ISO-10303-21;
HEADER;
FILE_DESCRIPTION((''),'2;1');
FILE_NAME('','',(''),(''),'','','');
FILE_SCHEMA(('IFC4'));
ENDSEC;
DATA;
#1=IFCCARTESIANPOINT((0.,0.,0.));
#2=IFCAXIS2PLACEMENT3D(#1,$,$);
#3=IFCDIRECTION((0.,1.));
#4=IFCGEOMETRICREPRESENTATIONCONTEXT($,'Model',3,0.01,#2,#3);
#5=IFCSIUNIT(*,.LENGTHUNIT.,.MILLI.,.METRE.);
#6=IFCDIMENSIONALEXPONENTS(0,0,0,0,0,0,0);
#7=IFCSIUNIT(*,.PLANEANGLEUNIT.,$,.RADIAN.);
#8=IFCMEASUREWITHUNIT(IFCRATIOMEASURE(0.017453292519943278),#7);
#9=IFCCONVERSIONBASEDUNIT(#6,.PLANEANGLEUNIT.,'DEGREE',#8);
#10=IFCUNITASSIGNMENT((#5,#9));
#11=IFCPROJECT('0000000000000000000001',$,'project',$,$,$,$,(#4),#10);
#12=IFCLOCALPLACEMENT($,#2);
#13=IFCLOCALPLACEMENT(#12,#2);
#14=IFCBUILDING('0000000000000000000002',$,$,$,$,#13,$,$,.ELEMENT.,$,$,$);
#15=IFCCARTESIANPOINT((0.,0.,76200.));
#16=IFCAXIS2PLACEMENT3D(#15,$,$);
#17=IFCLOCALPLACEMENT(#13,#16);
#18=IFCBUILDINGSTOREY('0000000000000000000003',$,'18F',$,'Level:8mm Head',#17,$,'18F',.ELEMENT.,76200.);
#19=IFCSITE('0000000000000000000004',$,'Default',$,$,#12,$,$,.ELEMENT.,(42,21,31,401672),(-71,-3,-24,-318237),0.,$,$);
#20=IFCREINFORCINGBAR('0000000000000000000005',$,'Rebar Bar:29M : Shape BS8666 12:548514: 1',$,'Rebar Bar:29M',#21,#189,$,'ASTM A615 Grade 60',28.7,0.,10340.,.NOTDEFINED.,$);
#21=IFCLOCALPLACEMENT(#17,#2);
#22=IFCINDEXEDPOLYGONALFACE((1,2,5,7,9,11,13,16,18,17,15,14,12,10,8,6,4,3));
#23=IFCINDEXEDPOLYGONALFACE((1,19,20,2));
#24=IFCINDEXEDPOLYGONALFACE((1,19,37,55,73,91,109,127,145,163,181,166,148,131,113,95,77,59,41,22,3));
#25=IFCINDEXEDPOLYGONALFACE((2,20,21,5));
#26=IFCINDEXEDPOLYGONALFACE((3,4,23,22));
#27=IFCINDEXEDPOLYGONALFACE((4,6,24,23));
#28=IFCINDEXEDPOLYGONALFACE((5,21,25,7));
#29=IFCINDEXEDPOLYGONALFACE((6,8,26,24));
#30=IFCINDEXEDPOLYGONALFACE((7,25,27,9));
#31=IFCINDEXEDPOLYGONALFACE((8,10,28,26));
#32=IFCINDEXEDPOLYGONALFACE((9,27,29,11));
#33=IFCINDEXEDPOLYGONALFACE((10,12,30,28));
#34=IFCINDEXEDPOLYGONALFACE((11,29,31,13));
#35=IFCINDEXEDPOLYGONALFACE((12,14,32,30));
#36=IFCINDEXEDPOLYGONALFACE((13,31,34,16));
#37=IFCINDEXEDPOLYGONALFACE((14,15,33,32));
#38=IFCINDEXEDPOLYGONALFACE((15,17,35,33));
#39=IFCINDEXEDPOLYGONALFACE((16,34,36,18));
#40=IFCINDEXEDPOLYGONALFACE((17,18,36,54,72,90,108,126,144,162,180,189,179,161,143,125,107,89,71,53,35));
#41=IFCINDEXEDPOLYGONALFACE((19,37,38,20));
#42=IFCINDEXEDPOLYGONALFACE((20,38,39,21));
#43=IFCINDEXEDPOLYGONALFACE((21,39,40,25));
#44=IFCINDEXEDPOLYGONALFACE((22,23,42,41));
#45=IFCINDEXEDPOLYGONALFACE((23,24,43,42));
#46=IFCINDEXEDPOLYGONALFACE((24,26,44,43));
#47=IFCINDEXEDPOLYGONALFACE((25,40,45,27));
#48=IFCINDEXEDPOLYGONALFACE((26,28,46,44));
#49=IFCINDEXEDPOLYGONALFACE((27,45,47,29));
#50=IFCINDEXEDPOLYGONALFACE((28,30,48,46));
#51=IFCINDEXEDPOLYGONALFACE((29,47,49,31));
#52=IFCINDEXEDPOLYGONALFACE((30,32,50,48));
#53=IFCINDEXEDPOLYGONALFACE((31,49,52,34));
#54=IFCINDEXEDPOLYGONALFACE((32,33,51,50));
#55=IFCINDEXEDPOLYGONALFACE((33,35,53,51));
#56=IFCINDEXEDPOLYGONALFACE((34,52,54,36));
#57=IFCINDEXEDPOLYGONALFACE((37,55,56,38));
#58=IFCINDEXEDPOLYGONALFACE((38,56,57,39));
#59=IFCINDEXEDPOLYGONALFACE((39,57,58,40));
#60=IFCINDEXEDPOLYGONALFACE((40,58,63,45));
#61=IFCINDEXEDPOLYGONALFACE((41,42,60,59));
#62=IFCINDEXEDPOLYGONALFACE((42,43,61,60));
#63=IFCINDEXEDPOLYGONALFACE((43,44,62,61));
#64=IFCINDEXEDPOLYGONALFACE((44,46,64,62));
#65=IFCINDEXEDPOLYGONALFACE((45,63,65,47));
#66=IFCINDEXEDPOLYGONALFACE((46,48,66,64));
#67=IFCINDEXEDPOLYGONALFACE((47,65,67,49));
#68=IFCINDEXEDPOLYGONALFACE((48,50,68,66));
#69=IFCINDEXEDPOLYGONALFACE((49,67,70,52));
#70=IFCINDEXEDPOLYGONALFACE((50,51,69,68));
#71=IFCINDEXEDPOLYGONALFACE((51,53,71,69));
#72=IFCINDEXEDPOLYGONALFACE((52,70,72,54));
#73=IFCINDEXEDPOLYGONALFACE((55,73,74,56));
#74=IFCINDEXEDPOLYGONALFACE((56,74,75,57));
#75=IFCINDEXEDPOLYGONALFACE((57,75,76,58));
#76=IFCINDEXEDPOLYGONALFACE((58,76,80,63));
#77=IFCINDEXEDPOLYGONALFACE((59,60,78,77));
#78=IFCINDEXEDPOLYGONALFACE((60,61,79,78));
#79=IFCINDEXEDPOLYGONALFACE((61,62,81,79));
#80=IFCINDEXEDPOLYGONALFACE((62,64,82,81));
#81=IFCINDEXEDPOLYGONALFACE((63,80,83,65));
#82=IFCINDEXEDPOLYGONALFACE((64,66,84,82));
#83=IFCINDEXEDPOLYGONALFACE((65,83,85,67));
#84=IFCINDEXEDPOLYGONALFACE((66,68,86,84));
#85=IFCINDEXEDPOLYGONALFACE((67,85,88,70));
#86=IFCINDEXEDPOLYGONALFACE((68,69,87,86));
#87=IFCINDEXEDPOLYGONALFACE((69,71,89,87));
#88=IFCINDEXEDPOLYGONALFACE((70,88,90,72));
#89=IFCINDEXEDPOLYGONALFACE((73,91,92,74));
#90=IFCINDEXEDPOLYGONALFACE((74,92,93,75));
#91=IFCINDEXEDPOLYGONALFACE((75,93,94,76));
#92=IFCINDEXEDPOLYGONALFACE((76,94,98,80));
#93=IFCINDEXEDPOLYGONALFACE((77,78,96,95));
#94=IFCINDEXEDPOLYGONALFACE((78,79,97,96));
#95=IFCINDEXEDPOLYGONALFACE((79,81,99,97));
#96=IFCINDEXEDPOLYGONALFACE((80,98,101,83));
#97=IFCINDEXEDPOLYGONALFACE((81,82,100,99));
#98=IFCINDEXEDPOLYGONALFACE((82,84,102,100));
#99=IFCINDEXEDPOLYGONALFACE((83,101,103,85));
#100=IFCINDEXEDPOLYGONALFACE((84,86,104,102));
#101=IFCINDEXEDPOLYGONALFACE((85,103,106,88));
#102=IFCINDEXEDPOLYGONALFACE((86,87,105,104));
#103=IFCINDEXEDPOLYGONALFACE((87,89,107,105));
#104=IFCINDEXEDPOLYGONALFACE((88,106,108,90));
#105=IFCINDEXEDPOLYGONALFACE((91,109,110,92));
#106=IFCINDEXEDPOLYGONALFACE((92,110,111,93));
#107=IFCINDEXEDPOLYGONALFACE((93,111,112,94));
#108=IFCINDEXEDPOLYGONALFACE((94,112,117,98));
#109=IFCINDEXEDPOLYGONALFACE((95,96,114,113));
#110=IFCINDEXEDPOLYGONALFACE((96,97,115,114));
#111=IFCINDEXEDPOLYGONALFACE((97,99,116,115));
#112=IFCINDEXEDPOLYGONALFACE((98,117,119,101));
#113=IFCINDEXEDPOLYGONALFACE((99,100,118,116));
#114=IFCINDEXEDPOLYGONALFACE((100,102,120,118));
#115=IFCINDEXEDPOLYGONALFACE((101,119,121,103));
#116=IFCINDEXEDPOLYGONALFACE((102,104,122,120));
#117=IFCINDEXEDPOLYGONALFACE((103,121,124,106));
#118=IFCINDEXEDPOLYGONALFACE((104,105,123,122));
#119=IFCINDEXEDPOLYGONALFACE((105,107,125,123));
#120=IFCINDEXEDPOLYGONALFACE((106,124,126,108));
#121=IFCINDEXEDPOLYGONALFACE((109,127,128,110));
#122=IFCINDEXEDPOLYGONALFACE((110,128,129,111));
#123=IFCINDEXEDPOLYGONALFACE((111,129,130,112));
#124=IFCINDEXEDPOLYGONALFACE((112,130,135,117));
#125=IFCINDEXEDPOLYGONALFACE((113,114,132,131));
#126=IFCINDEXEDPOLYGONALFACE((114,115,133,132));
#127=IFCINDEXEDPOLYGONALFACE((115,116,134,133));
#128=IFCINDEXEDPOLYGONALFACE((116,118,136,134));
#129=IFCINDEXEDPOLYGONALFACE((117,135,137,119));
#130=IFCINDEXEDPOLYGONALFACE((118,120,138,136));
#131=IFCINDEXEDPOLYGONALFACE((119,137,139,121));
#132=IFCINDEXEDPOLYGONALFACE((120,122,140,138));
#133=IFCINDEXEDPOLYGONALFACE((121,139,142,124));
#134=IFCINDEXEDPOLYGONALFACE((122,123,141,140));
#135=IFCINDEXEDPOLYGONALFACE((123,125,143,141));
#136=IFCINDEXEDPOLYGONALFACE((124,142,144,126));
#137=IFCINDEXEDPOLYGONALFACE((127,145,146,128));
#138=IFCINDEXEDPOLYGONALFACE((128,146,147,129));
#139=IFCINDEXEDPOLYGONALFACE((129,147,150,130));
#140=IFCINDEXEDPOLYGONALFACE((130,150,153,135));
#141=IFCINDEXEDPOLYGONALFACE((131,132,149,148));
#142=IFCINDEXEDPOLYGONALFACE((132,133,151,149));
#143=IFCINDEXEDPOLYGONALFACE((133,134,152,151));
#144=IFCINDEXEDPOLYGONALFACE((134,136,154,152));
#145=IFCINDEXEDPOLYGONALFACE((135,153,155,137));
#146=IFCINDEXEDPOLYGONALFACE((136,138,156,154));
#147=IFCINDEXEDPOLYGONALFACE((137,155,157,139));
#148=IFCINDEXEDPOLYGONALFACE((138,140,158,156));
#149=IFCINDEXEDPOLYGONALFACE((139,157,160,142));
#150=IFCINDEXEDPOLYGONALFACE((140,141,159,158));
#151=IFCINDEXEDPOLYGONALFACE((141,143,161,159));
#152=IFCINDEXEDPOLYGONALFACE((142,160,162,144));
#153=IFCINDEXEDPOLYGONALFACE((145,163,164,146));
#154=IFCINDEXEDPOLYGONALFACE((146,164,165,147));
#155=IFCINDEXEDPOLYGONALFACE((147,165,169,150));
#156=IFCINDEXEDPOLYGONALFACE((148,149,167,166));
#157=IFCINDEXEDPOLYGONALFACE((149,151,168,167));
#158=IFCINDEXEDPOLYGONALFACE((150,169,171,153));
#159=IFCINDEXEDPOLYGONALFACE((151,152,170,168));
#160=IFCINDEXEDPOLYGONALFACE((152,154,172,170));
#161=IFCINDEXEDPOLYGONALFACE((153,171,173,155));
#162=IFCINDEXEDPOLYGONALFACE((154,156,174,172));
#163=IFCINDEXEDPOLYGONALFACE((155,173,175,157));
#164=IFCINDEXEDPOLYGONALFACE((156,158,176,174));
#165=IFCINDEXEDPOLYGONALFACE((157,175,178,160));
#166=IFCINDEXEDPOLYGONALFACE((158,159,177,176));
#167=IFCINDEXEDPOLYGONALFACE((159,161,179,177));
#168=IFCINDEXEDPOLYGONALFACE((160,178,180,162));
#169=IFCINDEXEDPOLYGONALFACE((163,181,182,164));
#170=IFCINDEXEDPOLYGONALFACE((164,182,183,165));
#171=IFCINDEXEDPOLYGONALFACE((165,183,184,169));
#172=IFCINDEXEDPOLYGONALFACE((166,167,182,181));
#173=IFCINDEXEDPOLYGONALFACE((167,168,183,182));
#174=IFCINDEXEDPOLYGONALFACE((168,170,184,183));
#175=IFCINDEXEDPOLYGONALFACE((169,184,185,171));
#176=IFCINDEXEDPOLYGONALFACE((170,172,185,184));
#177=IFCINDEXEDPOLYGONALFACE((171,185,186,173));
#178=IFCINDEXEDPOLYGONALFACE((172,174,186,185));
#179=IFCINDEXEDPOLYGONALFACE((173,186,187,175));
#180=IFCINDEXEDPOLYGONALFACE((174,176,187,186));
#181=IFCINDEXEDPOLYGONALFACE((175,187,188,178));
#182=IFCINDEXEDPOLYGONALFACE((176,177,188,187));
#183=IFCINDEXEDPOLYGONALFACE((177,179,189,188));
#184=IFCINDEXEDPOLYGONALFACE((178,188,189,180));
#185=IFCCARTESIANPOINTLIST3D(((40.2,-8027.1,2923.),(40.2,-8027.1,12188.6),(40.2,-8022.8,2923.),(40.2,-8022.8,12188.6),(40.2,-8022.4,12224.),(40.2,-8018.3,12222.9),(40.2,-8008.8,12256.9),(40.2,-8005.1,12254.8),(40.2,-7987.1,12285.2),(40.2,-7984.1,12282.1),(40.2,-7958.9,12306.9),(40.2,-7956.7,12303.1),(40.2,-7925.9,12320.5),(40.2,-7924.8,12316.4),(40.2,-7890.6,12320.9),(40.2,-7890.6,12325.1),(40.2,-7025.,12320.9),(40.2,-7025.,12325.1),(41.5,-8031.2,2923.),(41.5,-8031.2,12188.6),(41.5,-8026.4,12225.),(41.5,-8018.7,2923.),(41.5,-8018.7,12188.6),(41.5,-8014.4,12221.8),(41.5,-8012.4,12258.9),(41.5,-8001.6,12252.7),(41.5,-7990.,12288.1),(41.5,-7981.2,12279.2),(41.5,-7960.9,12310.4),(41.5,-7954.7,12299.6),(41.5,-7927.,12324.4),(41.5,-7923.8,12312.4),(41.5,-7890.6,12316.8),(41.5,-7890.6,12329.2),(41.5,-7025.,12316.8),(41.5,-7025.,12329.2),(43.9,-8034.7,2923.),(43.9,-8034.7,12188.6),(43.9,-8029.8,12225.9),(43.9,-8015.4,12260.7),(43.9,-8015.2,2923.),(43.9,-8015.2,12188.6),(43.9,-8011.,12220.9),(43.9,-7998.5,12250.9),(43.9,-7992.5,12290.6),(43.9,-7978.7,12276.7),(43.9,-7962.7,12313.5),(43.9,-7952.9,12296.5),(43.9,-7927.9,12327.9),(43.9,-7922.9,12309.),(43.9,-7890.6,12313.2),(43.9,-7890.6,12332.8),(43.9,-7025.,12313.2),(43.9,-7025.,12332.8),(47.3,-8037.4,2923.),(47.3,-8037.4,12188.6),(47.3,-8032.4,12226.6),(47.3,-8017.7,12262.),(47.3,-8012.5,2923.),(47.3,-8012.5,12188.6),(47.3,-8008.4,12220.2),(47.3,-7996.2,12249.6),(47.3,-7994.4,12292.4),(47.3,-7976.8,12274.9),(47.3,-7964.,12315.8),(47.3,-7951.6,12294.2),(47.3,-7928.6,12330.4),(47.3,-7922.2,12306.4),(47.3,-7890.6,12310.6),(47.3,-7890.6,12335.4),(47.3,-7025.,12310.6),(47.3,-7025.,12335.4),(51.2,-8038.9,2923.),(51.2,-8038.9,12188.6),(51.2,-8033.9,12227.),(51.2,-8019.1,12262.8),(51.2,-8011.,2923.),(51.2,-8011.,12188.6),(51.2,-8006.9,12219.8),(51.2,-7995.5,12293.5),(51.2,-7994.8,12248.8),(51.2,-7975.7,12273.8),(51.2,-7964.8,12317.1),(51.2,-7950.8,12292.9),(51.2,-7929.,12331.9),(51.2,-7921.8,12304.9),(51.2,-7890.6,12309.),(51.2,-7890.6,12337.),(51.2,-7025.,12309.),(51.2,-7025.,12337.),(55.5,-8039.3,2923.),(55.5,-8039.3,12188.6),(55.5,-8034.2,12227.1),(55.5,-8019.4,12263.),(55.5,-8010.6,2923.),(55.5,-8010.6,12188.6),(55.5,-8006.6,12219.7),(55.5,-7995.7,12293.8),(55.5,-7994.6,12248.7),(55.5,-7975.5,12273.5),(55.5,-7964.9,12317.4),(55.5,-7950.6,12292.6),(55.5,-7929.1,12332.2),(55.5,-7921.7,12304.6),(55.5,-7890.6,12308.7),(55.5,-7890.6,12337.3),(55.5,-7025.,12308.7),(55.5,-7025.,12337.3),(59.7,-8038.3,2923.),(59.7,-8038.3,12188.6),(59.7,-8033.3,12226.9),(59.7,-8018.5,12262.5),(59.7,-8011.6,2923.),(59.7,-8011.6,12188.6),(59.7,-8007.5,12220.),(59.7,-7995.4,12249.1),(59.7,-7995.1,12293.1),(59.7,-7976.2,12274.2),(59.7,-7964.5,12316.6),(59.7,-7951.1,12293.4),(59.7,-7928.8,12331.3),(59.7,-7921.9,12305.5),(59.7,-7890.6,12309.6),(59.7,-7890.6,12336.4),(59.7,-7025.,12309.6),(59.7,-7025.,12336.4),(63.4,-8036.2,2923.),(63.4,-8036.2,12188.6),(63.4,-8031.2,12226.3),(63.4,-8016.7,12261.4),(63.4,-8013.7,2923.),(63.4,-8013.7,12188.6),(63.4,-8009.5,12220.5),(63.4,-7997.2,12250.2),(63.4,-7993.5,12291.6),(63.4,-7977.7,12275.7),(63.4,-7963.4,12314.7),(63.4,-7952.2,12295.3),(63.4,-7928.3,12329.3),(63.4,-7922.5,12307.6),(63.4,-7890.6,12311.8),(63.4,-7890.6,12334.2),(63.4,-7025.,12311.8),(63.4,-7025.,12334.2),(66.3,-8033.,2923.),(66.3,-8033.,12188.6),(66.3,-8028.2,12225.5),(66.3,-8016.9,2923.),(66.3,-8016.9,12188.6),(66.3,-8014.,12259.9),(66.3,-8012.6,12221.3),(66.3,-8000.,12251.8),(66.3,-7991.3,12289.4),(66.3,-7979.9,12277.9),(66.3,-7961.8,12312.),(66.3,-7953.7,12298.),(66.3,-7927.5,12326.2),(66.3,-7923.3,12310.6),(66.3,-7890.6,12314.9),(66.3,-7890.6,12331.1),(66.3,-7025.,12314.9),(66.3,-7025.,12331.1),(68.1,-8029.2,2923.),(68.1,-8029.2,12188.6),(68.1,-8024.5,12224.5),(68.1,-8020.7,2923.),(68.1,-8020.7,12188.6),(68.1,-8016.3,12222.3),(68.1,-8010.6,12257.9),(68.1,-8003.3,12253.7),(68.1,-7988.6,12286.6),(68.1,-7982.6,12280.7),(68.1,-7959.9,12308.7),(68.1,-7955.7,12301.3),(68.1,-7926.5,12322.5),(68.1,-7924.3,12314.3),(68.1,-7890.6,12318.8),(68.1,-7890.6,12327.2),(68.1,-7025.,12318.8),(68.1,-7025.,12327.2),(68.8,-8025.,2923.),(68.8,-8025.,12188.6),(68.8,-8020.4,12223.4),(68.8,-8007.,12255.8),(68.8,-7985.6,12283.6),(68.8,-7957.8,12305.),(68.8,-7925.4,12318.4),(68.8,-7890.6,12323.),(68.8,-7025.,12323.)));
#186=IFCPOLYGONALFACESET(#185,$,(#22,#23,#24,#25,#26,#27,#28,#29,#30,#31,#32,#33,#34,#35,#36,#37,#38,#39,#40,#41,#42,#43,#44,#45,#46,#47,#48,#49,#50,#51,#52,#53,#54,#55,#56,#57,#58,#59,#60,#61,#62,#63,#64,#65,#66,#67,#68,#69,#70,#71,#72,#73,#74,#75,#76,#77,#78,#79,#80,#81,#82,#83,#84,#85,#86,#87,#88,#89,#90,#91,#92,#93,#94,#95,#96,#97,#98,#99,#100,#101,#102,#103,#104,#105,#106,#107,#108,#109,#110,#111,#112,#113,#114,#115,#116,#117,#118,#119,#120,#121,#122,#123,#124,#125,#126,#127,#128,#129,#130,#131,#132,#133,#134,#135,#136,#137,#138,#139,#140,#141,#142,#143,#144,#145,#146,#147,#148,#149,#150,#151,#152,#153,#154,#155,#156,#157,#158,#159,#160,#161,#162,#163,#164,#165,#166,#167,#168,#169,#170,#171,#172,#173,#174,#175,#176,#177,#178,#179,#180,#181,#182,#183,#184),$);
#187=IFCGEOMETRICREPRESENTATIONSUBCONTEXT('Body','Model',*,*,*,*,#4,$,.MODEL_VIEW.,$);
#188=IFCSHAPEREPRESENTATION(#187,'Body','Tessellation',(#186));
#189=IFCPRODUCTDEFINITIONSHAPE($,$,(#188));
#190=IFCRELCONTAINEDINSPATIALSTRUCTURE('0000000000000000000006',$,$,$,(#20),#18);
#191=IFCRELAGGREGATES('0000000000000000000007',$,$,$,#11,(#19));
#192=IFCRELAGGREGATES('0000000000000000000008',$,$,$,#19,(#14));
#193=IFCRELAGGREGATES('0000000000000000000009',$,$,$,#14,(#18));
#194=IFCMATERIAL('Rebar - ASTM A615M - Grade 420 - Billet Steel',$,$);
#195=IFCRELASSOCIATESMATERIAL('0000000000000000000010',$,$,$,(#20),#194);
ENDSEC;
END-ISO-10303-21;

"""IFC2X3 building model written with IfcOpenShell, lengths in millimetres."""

from ifc_helpers import new_model, entity, si_unit, converted_unit, direction, frame, origin, place, context, subcontext, project, spatial, material, element, save


model = new_model("IFC2X3")

# Units and contexts
model_context = context("Model", 3, precision=0.01, world=origin(), true_north=direction((0.0, 1.0)))
body_context = subcontext(model_context, "Body", "Model", "MODEL_VIEW")
ifc_project = project(units=[si_unit("LENGTHUNIT", "METRE", prefix="MILLI"), converted_unit("PLANEANGLEUNIT", "DEGREE", entity("IfcRatioMeasure", 0.017453292519943278), si_unit("PLANEANGLEUNIT", "RADIAN"), dimensions=[0, 0, 0, 0, 0, 0, 0])], contexts=[model_context])

# Site, building, storey
site_placement = place(None, origin())
site = spatial("IfcSite", under=ifc_project, at=site_placement, Name="Default", CompositionType="ELEMENT", RefLatitude=(42, 21, 31, 401672), RefLongitude=(-71, -3, -24, -318237), RefElevation=0.0)
building_placement = place(site_placement, origin())
building = spatial("IfcBuilding", under=site, at=building_placement, CompositionType="ELEMENT")
storey_placement = place(building_placement, frame((0.0, 0.0, 76200.0)))
storey = spatial("IfcBuildingStorey", under=building, at=storey_placement, Name="18F", ObjectType="Level:8mm Head", LongName="18F", CompositionType="ELEMENT", Elevation=76200.0)

# Reinforcing bar
ifc_material_1 = material(Name="Rebar - ASTM A615M - Grade 420 - Billet Steel")
reinforcing_bar_1_placement = place(storey_placement, origin())
element("IfcReinforcingBar", 1, at=reinforcing_bar_1_placement, inside=storey, material=ifc_material_1, Name="Rebar Bar:29M : Shape BS8666 12:548514: 1", SteelGrade="ASTM A615 Grade 60", ObjectType="Rebar Bar:29M", BarLength=10340.0, BarRole="NOTDEFINED", CrossSectionArea=0.0, NominalDiameter=28.7, context=body_context, shape_type="AdvancedSweptSolid", body=[
    entity("IfcSweptDiskSolid", entity("IfcCompositeCurve", [entity("IfcCompositeCurveSegment", "CONTINUOUS", True, entity("IfcPolyline", [entity("IfcCartesianPoint", [54.4, -8025.0, 2923.0]), entity("IfcCartesianPoint", [54.4, -8025.0, 12188.6])])), entity("IfcCompositeCurveSegment", "CONTINUOUS", True, entity("IfcTrimmedCurve", entity("IfcCircle", entity("IfcAxis2Placement3D", entity("IfcCartesianPoint", [54.4, -7890.6, 12188.6]), entity("IfcDirection", [-1.0, 0.0, 0.0]), entity("IfcDirection", [0.0, 0.0, 1.0])), 134.3), [entity("IfcParameterValue", 270.0)], [entity("IfcParameterValue", 360.0)], True, "PARAMETER")), entity("IfcCompositeCurveSegment", "CONTINUOUS", True, entity("IfcPolyline", [entity("IfcCartesianPoint", [54.4, -7890.6, 12323.0]), entity("IfcCartesianPoint", [54.4, -7025.0, 12323.0])]))], False), 14.3, None, 0.0, 92.0),
])

save(model, "model.ifc")
